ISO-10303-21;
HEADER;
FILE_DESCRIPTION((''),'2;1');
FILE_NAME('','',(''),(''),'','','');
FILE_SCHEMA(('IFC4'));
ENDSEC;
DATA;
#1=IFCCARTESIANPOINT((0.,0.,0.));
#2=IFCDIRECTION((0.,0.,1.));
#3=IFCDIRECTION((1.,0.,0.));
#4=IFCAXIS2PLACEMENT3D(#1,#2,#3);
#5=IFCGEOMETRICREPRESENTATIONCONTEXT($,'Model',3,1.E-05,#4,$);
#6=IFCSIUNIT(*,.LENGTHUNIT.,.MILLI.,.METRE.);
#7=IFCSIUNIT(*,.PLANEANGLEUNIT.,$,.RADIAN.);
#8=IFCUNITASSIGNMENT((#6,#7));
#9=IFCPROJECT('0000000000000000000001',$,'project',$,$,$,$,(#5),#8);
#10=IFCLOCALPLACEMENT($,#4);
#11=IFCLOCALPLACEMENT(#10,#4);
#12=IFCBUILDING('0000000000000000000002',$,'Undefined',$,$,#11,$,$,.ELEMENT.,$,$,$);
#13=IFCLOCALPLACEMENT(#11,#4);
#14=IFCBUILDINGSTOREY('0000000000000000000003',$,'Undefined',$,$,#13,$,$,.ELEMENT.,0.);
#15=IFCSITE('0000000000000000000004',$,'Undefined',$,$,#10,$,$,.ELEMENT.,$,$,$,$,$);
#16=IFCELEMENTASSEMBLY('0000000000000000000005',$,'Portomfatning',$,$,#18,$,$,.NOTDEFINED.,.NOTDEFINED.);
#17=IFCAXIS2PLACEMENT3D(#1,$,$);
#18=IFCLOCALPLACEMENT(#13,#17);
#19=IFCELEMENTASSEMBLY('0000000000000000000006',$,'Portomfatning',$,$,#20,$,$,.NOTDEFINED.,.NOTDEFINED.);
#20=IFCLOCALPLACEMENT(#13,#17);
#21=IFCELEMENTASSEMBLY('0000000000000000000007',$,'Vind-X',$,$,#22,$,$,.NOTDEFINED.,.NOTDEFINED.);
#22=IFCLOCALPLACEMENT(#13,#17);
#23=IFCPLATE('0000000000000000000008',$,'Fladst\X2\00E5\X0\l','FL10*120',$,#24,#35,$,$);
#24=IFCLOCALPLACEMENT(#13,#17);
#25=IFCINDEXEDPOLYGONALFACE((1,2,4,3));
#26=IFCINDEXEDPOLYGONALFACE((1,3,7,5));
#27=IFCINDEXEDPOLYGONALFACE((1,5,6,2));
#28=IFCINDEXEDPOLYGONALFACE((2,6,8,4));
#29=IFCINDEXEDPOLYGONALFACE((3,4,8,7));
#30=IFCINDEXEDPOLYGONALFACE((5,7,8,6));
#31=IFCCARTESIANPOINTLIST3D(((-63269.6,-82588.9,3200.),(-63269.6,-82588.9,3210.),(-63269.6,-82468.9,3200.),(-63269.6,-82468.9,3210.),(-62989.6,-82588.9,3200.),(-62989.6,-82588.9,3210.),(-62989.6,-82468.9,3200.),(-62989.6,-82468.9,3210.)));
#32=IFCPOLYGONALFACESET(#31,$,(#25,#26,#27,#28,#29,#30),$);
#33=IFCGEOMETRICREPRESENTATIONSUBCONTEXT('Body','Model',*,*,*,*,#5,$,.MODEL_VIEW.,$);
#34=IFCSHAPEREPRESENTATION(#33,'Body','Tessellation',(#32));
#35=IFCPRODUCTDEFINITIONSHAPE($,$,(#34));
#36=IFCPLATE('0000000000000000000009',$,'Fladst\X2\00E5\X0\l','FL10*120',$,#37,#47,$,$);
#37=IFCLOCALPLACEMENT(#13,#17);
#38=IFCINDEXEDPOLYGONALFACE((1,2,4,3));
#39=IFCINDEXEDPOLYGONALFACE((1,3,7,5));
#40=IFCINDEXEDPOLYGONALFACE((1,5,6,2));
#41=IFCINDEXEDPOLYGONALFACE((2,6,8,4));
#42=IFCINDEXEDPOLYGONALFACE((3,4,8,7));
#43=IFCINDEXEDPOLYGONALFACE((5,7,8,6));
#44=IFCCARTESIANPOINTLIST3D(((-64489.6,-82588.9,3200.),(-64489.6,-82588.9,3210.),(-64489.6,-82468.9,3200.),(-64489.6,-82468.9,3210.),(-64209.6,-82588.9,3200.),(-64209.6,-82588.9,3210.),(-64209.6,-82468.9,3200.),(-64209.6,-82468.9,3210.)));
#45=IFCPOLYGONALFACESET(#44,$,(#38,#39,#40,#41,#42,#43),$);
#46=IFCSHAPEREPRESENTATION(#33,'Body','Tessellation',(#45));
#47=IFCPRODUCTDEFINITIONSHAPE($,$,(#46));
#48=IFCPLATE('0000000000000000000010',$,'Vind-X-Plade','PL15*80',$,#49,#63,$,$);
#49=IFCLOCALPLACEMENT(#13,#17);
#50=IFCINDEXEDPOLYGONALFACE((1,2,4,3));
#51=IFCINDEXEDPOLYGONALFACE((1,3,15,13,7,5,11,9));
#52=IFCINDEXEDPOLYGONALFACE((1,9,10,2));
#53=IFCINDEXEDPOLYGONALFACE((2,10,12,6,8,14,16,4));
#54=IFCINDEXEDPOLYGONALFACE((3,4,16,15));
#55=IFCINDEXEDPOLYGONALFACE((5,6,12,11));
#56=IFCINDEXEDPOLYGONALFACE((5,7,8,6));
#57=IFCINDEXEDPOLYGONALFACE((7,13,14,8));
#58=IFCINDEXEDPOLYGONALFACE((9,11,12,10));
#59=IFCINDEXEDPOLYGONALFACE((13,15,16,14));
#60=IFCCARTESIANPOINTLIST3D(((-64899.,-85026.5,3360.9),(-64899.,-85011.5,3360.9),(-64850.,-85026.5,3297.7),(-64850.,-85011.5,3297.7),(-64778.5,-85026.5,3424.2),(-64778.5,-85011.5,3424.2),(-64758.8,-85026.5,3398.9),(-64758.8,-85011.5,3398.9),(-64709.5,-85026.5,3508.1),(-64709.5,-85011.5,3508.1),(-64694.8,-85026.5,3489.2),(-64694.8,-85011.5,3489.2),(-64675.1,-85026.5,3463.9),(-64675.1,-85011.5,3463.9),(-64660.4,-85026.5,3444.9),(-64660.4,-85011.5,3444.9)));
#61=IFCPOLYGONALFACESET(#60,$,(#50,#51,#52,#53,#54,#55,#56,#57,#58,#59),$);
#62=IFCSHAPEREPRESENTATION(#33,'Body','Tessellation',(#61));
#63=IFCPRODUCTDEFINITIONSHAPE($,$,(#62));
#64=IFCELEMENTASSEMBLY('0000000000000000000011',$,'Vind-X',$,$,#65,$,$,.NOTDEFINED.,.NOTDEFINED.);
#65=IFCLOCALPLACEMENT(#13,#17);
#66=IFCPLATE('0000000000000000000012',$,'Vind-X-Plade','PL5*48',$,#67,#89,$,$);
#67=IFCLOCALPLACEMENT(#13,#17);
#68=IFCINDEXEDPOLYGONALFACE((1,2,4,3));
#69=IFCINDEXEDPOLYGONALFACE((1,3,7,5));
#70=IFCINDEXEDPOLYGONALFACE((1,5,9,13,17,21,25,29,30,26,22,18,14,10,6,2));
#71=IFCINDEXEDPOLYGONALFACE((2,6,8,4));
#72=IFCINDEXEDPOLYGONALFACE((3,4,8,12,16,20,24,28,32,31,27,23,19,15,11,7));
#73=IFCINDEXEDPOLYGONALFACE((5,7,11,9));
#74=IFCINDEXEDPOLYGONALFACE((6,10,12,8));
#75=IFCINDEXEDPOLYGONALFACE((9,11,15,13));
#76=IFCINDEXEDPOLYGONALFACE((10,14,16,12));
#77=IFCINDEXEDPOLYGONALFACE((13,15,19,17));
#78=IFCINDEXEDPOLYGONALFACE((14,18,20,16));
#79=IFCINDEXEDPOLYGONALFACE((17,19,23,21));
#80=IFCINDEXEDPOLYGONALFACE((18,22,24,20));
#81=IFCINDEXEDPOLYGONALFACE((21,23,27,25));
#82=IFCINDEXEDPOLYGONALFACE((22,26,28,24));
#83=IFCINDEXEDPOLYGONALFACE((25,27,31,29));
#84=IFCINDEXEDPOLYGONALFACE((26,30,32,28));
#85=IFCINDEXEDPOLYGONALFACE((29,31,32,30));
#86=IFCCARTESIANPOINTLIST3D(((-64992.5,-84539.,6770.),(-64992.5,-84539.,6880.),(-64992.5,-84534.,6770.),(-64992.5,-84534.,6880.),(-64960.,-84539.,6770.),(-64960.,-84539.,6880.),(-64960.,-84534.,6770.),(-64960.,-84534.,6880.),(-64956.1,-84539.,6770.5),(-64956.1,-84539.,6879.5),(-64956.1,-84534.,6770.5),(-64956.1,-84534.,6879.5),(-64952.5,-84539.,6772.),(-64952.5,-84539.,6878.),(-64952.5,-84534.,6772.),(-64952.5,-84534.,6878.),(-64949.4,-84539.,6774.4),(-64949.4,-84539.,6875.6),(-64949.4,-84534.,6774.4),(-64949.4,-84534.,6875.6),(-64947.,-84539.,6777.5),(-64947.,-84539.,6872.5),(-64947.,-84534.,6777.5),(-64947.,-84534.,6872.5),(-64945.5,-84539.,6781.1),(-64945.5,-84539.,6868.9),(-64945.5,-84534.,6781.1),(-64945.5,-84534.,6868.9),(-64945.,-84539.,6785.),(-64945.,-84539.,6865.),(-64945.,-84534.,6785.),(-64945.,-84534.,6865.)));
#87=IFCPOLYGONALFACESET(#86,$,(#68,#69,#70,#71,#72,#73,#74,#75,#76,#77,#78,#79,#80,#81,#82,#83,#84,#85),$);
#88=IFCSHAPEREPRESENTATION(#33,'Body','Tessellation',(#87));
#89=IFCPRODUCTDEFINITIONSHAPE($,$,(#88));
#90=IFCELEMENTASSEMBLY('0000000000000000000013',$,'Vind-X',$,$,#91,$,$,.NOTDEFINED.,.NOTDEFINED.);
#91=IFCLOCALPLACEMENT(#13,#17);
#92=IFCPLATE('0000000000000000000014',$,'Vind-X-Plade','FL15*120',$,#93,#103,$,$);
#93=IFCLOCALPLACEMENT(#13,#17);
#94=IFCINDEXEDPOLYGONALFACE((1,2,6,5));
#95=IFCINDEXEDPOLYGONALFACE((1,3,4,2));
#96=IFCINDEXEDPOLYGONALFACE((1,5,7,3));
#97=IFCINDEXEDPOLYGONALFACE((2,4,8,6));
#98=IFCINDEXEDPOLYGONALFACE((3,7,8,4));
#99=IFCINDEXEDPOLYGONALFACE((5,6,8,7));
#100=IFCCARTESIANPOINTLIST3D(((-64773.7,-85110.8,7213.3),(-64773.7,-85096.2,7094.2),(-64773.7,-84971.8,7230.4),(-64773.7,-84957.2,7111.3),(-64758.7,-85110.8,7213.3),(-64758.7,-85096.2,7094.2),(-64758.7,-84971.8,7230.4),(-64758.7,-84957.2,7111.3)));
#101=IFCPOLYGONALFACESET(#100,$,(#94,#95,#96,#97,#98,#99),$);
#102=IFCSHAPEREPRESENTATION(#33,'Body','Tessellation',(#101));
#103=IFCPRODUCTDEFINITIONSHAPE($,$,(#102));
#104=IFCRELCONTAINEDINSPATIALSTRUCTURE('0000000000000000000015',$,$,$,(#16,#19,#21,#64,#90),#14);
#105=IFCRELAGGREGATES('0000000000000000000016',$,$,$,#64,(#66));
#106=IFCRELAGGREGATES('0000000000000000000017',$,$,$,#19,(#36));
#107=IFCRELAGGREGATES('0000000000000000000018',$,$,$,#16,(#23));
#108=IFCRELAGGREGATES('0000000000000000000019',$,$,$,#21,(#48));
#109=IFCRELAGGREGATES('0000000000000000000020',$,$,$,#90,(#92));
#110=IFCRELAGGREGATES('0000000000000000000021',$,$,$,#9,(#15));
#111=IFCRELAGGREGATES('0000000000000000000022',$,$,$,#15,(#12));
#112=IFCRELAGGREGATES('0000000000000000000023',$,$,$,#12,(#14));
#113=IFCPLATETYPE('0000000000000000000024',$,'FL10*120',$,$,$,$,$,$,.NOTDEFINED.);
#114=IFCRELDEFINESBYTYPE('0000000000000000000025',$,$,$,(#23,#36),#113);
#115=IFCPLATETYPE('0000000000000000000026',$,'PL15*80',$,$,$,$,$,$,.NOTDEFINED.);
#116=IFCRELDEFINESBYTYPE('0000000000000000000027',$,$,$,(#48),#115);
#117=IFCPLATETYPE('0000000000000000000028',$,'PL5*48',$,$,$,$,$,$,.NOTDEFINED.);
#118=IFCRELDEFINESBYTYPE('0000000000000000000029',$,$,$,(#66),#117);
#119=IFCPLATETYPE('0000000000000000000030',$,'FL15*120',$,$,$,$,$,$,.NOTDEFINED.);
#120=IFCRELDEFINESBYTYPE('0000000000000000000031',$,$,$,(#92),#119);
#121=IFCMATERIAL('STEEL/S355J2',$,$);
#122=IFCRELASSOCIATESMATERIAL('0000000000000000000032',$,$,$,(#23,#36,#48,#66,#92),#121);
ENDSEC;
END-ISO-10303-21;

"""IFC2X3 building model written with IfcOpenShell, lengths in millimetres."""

from ifc_helpers import new_model, si_unit, frame, frame_2d, origin_with_axes, place, context, subcontext, project, spatial, polyline, circle_curve, parameter, trimmed, segment, composite_curve, outline, extrude, boolean, material, type_object, element, aggregate, save


model = new_model("IFC2X3")

# Units and contexts
model_context = context("Model", 3, precision=1e-05, world=origin_with_axes())
body_context = subcontext(model_context, "Body", "Model", "MODEL_VIEW")
ifc_project = project(units=[si_unit("LENGTHUNIT", "METRE", prefix="MILLI"), si_unit("PLANEANGLEUNIT", "RADIAN")], contexts=[model_context])

# Site, building, storey
site_placement = place(None, origin_with_axes())
site = spatial("IfcSite", under=ifc_project, at=site_placement, Name="Undefined", CompositionType="ELEMENT")
building_placement = place(site_placement, origin_with_axes())
building = spatial("IfcBuilding", under=site, at=building_placement, Name="Undefined", CompositionType="ELEMENT")
storey_placement = place(building_placement, origin_with_axes())
storey = spatial("IfcBuildingStorey", under=building, at=storey_placement, Name="Undefined", CompositionType="ELEMENT", Elevation=0.0)

# Element assemblies
assembly_1_placement = place(storey_placement, origin_with_axes())
assembly_1 = element("IfcElementAssembly", 1, at=assembly_1_placement, inside=storey, Name="Portomfatning", AssemblyPlace="NOTDEFINED", PredefinedType="NOTDEFINED")
assembly_2_placement = place(storey_placement, origin_with_axes())
assembly_2 = element("IfcElementAssembly", 2, at=assembly_2_placement, inside=storey, Name="Portomfatning", AssemblyPlace="NOTDEFINED", PredefinedType="NOTDEFINED")

# Element assembly
assembly_3_placement = place(storey_placement, origin_with_axes())
assembly_3 = element("IfcElementAssembly", 3, at=assembly_3_placement, inside=storey, Name="Vind-X", AssemblyPlace="NOTDEFINED", PredefinedType="NOTDEFINED")
ifc_material_1 = material(Name="STEEL/S355J2")

# Plates
plate_type_1 = type_object("IfcPlateType", Name="FL10*120", PredefinedType="NOTDEFINED")
plate_1_placement = place(assembly_1_placement, frame((-63129.6, -82468.9, 3205.0), z_axis=(0.0, 0.0, 1.0), x_axis=(0.0, -1.0, 0.0)))
plate_1 = element("IfcPlate", 4, at=plate_1_placement, type_object=plate_type_1, material=ifc_material_1, Name="Fladstål", Description="FL10*120", context=body_context, shape_type="SweptSolid", body=[
    extrude(outline(polyline([(0.0, -140.0), (0.0, 140.0), (120.0, 140.0), (120.0, -140.0), (0.0, -140.0)])), frame((0.0, 0.0, -5.0), z_axis=(0.0, 0.0, 1.0), x_axis=(1.0, 0.0, 0.0)), (0.0, 0.0, 1.0), 10.0),
])
plate_2_placement = place(assembly_2_placement, frame((-64349.6, -82468.9, 3205.0), z_axis=(0.0, 0.0, 1.0), x_axis=(0.0, -1.0, 0.0)))
plate_2 = element("IfcPlate", 5, at=plate_2_placement, type_object=plate_type_1, material=ifc_material_1, Name="Fladstål", Description="FL10*120", context=body_context, shape_type="SweptSolid", body=[
    extrude(outline(polyline([(0.0, -140.0), (0.0, 140.0), (120.0, 140.0), (120.0, -140.0), (0.0, -140.0)])), frame((0.0, 0.0, -5.0), z_axis=(0.0, 0.0, 1.0), x_axis=(1.0, 0.0, 0.0)), (0.0, 0.0, 1.0), 10.0),
])
plate_type_2 = type_object("IfcPlateType", Name="PL15*80", PredefinedType="NOTDEFINED")
plate_3_placement = place(assembly_3_placement, frame((-64850.0, -85019.0, 3297.7), z_axis=(0.0, 1.0, 0.0), x_axis=(-0.613349, 0.0, 0.789812)))
plate_3 = element("IfcPlate", 6, at=plate_3_placement, type_object=plate_type_2, material=ifc_material_1, Name="Vind-X-Plade", Description="PL15*80", context=body_context, shape_type="CSG", body=[
    boolean("DIFFERENCE", extrude(outline(polyline([(0.0, 0.0), (80.0, 0.0), (80.0, 240.0), (0.0, 240.0), (0.0, 0.0)])), frame((0.0, 0.0, -7.5), z_axis=(0.0, 0.0, 1.0), x_axis=(1.0, 0.0, 0.0)), (0.0, 0.0, 1.0), 15.0), extrude(outline(polyline([(0.0, 0.0), (106.0, 0.0), (106.0, 32.0), (0.0, 32.0), (0.0, 0.0)])), frame((56.0, 240.0, 8.5), z_axis=(0.0, 0.0, -1.0), x_axis=(0.0, -1.0, 0.0)), (0.0, 0.0, 1.0), 17.0)),
])

# Element assemblies, plates
assembly_4_placement = place(storey_placement, origin_with_axes())
assembly_4 = element("IfcElementAssembly", 7, at=assembly_4_placement, inside=storey, Name="Vind-X", AssemblyPlace="NOTDEFINED", PredefinedType="NOTDEFINED")
plate_type_3 = type_object("IfcPlateType", Name="PL5*48", PredefinedType="NOTDEFINED")
plate_4_placement = place(assembly_4_placement, frame((-64945.0, -84536.5, 6770.0), z_axis=(0.0, 1.0, 0.0), x_axis=(-1.0, 0.0, 0.0)))
plate_4 = element("IfcPlate", 8, at=plate_4_placement, type_object=plate_type_3, material=ifc_material_1, Name="Vind-X-Plade", Description="PL5*48", context=body_context, shape_type="SweptSolid", body=[
    extrude(outline(composite_curve([segment(trimmed(circle_curve(frame_2d((15.0, 15.0), x_axis=(-1.0, 0.0)), 15.0), [parameter(0.0)], [parameter(1.570796)], True, "PARAMETER"), True, "CONTINUOUS"), segment(polyline([(15.0, 0.0), (47.5, 0.0), (47.5, 110.0), (15.0, 110.0)]), True, "CONTINUOUS"), segment(trimmed(circle_curve(frame_2d((15.0, 95.0), x_axis=(0.0, 1.0)), 15.0), [parameter(0.0)], [parameter(1.570796)], True, "PARAMETER"), True, "CONTINUOUS"), segment(polyline([(0.0, 95.0), (0.0, 15.0)]), True, "CONTINUOUS")], self_intersect=True)), frame((0.0, 0.0, -2.5), z_axis=(0.0, 0.0, 1.0), x_axis=(1.0, 0.0, 0.0)), (0.0, 0.0, 1.0), 5.0),
])
aggregate(assembly_4, [plate_4])
assembly_5_placement = place(storey_placement, origin_with_axes())
assembly_5 = element("IfcElementAssembly", 9, at=assembly_5_placement, inside=storey, Name="Vind-X", AssemblyPlace="NOTDEFINED", PredefinedType="NOTDEFINED")
plate_type_4 = type_object("IfcPlateType", Name="FL15*120", PredefinedType="NOTDEFINED")
plate_5_placement = place(assembly_5_placement, frame((-64766.2, -84957.2, 7111.3), z_axis=(-1.0, 0.0, 0.0), x_axis=(0.0, -0.992546, -0.121869)))
plate_5 = element("IfcPlate", 10, at=plate_5_placement, type_object=plate_type_4, material=ifc_material_1, Name="Vind-X-Plade", Description="FL15*120", context=body_context, shape_type="SweptSolid", body=[
    extrude(outline(polyline([(0.0, 0.0), (140.0, 0.0), (140.0, 120.0), (0.0, 120.0), (0.0, 0.0)])), frame((0.0, 0.0, -7.5), z_axis=(0.0, 0.0, 1.0), x_axis=(1.0, 0.0, 0.0)), (0.0, 0.0, 1.0), 15.0),
])

aggregate(assembly_2, [plate_2])
aggregate(assembly_1, [plate_1])
aggregate(assembly_3, [plate_3])
aggregate(assembly_5, [plate_5])

save(model, "model.ifc")
